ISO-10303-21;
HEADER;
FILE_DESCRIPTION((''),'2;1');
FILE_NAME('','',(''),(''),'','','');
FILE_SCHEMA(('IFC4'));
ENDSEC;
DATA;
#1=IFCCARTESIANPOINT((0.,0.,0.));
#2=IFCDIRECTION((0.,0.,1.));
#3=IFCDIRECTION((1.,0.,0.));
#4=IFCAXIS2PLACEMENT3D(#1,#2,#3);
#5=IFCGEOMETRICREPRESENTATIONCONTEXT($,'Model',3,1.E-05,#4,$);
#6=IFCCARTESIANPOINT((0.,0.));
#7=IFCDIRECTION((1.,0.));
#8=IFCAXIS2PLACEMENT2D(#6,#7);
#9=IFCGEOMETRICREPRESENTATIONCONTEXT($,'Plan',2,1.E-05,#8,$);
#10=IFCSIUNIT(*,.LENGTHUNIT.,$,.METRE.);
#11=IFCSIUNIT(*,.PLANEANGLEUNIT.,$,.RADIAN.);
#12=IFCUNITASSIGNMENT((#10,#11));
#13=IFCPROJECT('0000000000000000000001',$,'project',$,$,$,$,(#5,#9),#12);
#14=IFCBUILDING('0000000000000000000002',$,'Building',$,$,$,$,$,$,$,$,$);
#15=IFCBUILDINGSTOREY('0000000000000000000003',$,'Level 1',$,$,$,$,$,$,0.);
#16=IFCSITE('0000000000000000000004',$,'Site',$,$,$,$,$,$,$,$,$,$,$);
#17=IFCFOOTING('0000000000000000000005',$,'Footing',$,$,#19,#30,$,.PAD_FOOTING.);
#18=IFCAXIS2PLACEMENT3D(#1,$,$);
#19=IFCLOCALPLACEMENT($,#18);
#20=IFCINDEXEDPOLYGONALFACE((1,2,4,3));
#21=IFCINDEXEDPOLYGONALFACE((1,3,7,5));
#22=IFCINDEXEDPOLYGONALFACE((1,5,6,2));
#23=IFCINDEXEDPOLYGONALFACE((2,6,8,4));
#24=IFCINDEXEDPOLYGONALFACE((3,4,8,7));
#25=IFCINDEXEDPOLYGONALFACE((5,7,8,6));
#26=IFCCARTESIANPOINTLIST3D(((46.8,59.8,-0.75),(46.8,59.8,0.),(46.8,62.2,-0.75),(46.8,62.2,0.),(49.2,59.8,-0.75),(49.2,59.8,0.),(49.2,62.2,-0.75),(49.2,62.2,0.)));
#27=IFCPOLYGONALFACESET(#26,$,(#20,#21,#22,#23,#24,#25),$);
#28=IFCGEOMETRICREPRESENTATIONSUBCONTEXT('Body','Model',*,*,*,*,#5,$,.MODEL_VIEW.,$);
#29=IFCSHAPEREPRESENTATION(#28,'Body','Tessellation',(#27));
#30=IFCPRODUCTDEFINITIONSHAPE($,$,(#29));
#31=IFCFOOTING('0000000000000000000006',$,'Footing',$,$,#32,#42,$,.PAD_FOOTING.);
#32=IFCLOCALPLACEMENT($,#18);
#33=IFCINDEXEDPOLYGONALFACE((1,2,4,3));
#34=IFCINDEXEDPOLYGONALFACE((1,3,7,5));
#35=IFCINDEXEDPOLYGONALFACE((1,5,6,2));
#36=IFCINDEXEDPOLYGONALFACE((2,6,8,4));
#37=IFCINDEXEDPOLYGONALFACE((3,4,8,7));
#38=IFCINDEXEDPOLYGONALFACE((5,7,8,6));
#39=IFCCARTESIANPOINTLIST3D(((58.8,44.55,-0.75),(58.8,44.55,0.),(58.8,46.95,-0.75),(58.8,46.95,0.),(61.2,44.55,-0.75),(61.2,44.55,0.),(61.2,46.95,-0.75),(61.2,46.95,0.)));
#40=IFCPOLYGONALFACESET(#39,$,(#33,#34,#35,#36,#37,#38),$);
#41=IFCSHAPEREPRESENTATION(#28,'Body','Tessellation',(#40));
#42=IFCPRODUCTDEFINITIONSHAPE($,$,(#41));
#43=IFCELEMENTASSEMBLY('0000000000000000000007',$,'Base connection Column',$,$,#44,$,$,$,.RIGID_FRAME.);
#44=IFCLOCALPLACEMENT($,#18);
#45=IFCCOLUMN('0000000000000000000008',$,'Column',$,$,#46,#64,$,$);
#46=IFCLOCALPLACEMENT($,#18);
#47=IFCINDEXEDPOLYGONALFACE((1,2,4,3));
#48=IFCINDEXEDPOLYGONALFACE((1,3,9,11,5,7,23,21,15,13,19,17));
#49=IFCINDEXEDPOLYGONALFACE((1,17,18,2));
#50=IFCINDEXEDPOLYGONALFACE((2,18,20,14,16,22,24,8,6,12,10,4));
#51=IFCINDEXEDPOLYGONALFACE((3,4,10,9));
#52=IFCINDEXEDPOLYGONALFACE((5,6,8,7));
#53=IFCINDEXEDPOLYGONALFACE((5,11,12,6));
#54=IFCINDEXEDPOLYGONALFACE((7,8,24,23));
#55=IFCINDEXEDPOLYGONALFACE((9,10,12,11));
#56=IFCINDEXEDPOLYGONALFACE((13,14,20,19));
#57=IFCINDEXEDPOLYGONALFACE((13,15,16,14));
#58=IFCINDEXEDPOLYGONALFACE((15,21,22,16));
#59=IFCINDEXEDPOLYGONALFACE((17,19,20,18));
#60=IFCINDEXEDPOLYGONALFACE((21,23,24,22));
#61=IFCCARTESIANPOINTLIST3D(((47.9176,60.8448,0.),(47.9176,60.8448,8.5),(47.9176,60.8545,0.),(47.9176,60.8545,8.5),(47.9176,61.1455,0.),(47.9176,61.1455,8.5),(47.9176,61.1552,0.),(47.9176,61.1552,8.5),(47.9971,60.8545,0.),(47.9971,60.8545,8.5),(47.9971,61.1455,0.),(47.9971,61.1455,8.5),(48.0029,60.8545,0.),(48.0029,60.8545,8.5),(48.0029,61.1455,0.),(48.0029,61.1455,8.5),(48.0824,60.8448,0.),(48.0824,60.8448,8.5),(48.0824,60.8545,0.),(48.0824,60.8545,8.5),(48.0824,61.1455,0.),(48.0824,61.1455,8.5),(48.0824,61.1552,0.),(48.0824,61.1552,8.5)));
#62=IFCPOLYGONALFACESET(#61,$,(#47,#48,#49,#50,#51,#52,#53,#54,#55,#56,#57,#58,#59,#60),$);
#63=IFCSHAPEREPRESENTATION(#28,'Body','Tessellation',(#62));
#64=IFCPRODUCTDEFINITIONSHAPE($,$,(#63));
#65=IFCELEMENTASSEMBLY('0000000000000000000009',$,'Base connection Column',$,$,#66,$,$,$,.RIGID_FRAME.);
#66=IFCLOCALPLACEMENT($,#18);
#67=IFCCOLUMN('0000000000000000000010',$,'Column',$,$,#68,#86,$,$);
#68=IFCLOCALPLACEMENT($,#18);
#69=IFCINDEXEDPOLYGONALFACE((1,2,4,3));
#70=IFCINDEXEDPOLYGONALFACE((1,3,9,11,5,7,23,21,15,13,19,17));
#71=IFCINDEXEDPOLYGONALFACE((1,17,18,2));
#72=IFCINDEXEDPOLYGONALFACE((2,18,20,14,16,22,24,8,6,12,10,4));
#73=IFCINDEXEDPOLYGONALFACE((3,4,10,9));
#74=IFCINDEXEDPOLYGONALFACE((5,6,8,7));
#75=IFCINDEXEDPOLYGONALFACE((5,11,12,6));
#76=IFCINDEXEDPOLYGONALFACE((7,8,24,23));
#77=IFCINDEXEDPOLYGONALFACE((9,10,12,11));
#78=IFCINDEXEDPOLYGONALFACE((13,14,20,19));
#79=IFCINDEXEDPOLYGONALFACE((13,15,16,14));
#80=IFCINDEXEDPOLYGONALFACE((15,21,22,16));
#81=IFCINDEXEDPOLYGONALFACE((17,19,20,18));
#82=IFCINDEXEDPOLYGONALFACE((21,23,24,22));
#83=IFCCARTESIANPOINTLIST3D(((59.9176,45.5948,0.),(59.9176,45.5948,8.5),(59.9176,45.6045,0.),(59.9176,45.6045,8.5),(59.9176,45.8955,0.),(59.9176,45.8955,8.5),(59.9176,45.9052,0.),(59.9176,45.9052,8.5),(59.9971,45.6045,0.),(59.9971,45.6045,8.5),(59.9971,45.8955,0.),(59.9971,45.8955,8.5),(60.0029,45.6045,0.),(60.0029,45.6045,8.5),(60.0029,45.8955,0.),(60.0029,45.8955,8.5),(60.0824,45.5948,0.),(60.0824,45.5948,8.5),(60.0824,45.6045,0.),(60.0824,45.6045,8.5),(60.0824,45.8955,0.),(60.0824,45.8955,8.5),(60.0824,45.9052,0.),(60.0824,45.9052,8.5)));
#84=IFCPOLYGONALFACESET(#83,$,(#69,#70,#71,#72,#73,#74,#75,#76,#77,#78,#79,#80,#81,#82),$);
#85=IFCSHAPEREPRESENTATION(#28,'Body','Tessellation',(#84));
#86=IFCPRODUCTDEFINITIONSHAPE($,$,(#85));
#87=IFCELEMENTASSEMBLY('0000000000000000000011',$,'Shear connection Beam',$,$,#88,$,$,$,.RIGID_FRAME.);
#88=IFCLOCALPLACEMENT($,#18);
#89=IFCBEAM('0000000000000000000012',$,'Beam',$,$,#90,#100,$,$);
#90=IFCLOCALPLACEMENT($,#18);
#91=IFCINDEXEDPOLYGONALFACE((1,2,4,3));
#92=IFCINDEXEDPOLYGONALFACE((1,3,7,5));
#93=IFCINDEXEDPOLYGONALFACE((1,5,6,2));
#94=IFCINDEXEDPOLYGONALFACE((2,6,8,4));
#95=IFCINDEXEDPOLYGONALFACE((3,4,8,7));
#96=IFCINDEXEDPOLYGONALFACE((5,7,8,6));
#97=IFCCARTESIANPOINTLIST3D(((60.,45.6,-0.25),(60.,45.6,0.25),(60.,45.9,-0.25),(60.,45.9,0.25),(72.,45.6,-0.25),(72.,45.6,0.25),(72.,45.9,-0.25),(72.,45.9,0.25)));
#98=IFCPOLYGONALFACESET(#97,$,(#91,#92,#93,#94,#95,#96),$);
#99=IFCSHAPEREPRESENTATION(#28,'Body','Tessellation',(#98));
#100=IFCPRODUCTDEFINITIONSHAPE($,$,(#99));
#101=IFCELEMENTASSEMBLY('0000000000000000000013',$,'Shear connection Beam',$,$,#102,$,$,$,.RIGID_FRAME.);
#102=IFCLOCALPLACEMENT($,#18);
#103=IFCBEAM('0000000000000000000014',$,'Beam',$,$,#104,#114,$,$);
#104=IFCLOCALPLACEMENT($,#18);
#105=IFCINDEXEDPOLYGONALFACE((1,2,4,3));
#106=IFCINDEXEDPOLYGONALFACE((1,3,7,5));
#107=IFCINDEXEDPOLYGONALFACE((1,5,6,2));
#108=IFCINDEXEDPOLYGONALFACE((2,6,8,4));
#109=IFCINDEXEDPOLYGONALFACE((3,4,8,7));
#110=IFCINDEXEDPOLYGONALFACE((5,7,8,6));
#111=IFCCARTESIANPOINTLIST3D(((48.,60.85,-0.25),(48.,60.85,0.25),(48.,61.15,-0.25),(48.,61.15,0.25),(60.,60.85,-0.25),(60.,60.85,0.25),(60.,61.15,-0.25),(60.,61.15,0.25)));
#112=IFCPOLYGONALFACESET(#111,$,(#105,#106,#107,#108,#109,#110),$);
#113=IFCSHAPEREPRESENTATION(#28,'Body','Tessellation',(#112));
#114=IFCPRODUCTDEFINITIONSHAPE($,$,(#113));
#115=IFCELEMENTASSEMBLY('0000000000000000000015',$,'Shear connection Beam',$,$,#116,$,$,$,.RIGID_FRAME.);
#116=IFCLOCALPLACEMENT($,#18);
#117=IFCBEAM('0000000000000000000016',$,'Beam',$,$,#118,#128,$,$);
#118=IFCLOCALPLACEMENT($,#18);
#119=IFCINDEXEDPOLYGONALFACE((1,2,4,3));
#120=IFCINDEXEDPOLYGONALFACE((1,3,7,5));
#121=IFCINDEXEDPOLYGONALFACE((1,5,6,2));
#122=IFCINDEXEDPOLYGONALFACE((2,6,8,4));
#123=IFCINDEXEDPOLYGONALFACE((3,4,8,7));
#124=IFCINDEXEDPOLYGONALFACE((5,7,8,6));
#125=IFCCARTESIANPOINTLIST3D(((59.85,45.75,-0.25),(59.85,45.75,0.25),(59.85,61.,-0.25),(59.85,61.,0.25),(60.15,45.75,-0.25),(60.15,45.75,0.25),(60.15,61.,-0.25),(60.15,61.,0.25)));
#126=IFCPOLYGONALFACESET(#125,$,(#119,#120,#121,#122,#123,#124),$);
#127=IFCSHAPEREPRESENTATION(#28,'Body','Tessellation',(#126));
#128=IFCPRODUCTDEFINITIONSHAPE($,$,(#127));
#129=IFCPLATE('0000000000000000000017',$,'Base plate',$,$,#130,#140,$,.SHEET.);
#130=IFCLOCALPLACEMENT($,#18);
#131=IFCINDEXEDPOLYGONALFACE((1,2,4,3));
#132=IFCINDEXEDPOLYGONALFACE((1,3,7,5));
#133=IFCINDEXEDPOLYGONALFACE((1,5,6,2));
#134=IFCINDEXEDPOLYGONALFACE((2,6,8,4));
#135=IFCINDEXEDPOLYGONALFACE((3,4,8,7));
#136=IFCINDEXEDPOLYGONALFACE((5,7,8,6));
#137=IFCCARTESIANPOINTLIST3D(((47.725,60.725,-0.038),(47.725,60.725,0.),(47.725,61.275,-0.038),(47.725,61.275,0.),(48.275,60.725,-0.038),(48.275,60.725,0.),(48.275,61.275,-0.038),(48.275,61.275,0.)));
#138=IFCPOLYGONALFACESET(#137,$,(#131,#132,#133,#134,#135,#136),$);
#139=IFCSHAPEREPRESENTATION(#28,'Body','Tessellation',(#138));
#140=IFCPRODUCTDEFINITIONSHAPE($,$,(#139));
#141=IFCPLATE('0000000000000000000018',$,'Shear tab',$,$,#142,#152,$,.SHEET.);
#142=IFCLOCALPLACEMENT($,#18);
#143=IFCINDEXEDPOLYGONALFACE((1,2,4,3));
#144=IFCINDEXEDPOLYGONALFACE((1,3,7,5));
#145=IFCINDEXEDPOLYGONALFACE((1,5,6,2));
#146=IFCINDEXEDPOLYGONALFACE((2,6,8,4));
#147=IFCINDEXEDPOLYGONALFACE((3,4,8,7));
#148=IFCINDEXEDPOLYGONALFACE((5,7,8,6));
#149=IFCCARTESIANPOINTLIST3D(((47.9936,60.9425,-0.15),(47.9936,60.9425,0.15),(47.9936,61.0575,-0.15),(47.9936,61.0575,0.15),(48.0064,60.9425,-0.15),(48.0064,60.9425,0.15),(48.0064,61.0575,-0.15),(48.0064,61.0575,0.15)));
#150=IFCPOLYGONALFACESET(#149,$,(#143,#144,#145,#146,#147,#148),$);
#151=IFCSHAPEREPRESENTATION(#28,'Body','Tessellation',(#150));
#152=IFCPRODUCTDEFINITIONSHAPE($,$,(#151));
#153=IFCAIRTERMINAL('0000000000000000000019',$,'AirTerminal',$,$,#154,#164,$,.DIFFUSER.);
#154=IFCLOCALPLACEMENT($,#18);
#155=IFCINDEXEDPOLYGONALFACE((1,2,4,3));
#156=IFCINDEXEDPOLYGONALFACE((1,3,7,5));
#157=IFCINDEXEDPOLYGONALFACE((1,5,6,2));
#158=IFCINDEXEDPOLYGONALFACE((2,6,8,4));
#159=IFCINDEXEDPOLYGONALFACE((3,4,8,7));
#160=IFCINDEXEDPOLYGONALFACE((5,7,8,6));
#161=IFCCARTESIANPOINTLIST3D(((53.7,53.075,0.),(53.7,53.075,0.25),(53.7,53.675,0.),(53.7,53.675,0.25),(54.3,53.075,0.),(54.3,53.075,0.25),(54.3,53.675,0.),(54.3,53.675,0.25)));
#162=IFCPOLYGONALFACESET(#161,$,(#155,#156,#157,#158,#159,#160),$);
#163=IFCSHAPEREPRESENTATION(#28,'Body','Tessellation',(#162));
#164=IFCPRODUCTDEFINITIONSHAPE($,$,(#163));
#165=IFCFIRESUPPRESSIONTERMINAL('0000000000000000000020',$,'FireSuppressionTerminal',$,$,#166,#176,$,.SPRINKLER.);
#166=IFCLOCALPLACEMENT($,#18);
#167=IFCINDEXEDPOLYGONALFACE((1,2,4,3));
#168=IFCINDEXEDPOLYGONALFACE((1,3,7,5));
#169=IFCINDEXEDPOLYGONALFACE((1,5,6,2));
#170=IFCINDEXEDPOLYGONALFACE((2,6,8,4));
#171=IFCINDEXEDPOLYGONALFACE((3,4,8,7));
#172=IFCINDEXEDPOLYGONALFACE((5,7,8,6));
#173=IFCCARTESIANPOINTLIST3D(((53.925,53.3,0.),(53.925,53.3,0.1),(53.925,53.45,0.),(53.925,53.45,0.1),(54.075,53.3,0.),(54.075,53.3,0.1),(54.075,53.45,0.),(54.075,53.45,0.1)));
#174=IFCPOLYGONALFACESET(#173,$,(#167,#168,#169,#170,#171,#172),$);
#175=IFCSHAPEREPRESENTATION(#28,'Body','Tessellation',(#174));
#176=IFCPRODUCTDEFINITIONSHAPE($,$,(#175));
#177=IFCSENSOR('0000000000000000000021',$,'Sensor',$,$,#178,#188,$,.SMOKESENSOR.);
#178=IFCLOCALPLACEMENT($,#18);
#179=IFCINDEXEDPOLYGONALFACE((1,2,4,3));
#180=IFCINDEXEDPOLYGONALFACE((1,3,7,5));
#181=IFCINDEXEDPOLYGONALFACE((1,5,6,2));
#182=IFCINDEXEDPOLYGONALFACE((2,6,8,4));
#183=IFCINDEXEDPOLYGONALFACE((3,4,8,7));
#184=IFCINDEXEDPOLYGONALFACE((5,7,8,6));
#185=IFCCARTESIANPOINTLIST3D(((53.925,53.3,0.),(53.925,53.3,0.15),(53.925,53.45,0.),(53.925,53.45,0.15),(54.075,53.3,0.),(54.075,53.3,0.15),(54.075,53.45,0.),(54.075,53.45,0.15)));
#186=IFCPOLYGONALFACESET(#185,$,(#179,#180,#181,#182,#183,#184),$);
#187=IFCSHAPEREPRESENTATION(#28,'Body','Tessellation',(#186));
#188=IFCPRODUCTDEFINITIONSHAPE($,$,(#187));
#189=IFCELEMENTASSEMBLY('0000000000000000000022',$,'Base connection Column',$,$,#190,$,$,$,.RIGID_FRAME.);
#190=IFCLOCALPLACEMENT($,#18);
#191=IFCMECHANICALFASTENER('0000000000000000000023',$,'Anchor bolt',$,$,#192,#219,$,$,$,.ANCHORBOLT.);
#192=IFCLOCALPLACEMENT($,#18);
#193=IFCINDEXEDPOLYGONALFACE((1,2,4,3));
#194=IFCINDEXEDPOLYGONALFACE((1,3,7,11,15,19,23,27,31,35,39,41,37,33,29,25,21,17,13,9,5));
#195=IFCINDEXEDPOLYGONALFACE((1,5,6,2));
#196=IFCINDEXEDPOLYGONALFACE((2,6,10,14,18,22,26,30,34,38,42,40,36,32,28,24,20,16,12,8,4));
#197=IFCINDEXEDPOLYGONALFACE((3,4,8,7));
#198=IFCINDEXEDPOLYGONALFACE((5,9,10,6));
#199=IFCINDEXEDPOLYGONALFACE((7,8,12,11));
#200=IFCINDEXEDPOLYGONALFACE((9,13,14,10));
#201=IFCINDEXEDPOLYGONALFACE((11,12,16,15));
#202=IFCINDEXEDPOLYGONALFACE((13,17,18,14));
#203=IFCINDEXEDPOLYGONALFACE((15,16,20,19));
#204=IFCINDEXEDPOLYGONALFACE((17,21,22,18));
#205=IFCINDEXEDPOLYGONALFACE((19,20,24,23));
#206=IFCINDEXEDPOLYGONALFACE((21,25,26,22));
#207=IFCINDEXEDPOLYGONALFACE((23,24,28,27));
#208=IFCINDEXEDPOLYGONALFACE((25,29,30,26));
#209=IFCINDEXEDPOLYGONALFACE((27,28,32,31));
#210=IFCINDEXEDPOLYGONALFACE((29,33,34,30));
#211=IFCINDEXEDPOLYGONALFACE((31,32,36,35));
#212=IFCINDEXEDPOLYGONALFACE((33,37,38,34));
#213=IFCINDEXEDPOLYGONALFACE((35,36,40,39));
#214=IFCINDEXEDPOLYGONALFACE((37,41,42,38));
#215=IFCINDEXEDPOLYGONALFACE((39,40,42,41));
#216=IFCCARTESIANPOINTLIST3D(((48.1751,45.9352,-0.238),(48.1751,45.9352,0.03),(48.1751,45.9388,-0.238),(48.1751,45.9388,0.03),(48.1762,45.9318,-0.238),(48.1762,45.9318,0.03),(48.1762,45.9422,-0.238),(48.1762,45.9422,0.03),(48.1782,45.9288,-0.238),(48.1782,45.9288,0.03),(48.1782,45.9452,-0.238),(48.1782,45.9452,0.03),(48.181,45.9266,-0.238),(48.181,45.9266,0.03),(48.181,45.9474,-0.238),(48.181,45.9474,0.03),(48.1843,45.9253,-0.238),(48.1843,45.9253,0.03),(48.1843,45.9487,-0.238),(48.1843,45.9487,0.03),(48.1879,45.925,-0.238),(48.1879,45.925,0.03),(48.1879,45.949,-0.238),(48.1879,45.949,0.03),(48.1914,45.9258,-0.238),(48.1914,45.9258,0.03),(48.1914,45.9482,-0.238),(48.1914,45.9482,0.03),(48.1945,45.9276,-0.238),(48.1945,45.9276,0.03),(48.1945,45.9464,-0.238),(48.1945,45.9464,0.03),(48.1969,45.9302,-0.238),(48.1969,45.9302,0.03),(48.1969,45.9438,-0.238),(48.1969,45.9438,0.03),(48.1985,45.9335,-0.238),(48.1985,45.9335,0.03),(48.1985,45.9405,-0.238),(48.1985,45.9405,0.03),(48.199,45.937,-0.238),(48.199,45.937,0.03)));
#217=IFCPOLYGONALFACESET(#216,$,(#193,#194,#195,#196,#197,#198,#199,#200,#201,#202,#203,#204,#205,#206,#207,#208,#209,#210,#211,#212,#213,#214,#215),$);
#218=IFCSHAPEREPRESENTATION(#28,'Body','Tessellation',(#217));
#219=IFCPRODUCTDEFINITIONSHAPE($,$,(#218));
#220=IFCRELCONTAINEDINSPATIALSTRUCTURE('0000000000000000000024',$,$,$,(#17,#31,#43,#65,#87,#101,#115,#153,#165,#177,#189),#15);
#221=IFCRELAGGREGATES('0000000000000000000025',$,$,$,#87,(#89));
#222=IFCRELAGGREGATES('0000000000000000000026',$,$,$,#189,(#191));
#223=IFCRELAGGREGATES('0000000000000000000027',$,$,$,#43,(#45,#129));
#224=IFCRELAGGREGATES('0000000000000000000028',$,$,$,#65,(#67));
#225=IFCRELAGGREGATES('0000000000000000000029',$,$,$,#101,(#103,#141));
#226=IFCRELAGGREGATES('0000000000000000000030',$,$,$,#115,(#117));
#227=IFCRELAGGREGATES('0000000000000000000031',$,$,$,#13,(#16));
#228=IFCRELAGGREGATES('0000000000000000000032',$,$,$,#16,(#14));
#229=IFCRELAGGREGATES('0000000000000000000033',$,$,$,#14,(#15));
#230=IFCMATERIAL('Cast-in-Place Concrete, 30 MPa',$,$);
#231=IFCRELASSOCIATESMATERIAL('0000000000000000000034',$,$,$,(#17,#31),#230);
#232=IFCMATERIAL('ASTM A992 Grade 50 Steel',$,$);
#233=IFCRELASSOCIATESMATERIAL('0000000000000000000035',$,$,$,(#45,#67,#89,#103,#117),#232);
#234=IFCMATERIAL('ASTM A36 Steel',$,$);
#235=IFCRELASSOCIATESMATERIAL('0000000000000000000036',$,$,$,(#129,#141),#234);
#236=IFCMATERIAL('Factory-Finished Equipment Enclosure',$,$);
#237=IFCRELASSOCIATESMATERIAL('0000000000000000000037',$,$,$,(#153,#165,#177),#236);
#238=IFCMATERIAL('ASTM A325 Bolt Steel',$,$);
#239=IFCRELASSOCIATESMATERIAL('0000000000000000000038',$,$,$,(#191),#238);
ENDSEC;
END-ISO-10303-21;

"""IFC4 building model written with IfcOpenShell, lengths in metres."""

from ifc_helpers import new_model, si_unit, frame, origin_with_axes, origin_2d, origin_2d_with_axis, place, context, subcontext, project, spatial, rectangle, circle, i_section, extrude, material, element, aggregate, save


model = new_model("IFC4")

# Units and contexts
model_context = context("Model", 3, precision=1e-05, world=origin_with_axes())
plan_context = context("Plan", 2, precision=1e-05, world=origin_2d_with_axis())
body_context = subcontext(model_context, "Body", "Model", "MODEL_VIEW")
ifc_project = project(units=[si_unit("LENGTHUNIT", "METRE"), si_unit("PLANEANGLEUNIT", "RADIAN")], contexts=[model_context, plan_context])

# Site, building, storey
site = spatial("IfcSite", under=ifc_project, Name="Site")
building = spatial("IfcBuilding", under=site, Name="Building")
storey = spatial("IfcBuildingStorey", under=building, Name="Level 1", Elevation=0.0)

# Footings
ifc_material_1 = material(Name="Cast-in-Place Concrete, 30 MPa")
for number, where, z_axis, x_axis, name in (
    (1, (48.0, 61.0, -0.75), (0.0, 0.0, 1.0), (1.0, 0.0, 0.0), "Footing"),
    (2, (60.0, 45.75, -0.75), (0.0, 0.0, 1.0), (1.0, 0.0, 0.0), "Footing"),
):
    element("IfcFooting", number, at=place(None, frame(where, z_axis=z_axis, x_axis=x_axis)), inside=storey, material=ifc_material_1, Name=name, PredefinedType="PAD_FOOTING", context=body_context, shape_type="SweptSolid", body=[
        extrude(rectangle(XDim=2.4, YDim=2.4, at=origin_2d_with_axis()), origin_with_axes(), (0.0, 0.0, 1.0), 0.75),
    ])

# Element assemblies, columns
assembly_1 = element("IfcElementAssembly", 3, inside=storey, Name="Base connection Column", PredefinedType="RIGID_FRAME")
ifc_material_2 = material(Name="ASTM A992 Grade 50 Steel")
column_1_placement = place(None, frame((48.0, 61.0, 0.0), z_axis=(0.0, 0.0, 1.0), x_axis=(1.0, 0.0, 0.0)))
column_1 = element("IfcColumn", 4, at=column_1_placement, material=ifc_material_2, Name="Column", context=body_context, shape_type="SweptSolid", body=[
    extrude(i_section(OverallWidth=0.1648, OverallDepth=0.3104, WebThickness=0.0058, FlangeThickness=0.0097, at=origin_2d_with_axis()), origin_with_axes(), (0.0, 0.0, 1.0), 8.5),
])
assembly_2 = element("IfcElementAssembly", 5, inside=storey, Name="Base connection Column", PredefinedType="RIGID_FRAME")
column_2_placement = place(None, frame((60.0, 45.75, 0.0), z_axis=(0.0, 0.0, 1.0), x_axis=(1.0, 0.0, 0.0)))
column_2 = element("IfcColumn", 6, at=column_2_placement, material=ifc_material_2, Name="Column", context=body_context, shape_type="SweptSolid", body=[
    extrude(i_section(OverallWidth=0.1648, OverallDepth=0.3104, WebThickness=0.0058, FlangeThickness=0.0097, at=origin_2d_with_axis()), origin_with_axes(), (0.0, 0.0, 1.0), 8.5),
])

# Element assemblies, beams
assembly_3 = element("IfcElementAssembly", 7, inside=storey, Name="Shear connection Beam", PredefinedType="RIGID_FRAME")
beam_1_placement = place(None, frame((60.0, 45.75, 0.0), z_axis=(1.0, 0.0, 0.0), x_axis=(0.0, 1.0, 0.0)))
beam_1 = element("IfcBeam", 8, at=beam_1_placement, material=ifc_material_2, Name="Beam", context=body_context, shape_type="SweptSolid", body=[
    extrude(rectangle(XDim=0.3, YDim=0.5, at=origin_2d_with_axis()), origin_with_axes(), (0.0, 0.0, 1.0), 12.0),
])
aggregate(assembly_3, [beam_1])
assembly_4 = element("IfcElementAssembly", 9, inside=storey, Name="Shear connection Beam", PredefinedType="RIGID_FRAME")
beam_2_placement = place(None, frame((48.0, 61.0, 0.0), z_axis=(1.0, 0.0, 0.0), x_axis=(0.0, 1.0, 0.0)))
beam_2 = element("IfcBeam", 10, at=beam_2_placement, material=ifc_material_2, Name="Beam", context=body_context, shape_type="SweptSolid", body=[
    extrude(rectangle(XDim=0.3, YDim=0.5, at=origin_2d_with_axis()), origin_with_axes(), (0.0, 0.0, 1.0), 12.0),
])
assembly_5 = element("IfcElementAssembly", 11, inside=storey, Name="Shear connection Beam", PredefinedType="RIGID_FRAME")
beam_3_placement = place(None, frame((60.0, 45.75, 0.0), z_axis=(0.0, 1.0, 0.0), x_axis=(-1.0, 0.0, 0.0)))
beam_3 = element("IfcBeam", 12, at=beam_3_placement, material=ifc_material_2, Name="Beam", context=body_context, shape_type="SweptSolid", body=[
    extrude(rectangle(XDim=0.3, YDim=0.5, at=origin_2d_with_axis()), origin_with_axes(), (0.0, 0.0, 1.0), 15.25),
])

# Plates
ifc_material_3 = material(Name="ASTM A36 Steel")
plate_1_placement = place(None, frame((48.0, 61.0, -0.038), z_axis=(0.0, 0.0, 1.0), x_axis=(1.0, 0.0, 0.0)))
plate_1 = element("IfcPlate", 13, at=plate_1_placement, material=ifc_material_3, Name="Base plate", PredefinedType="SHEET", context=body_context, shape_type="SweptSolid", body=[
    extrude(rectangle(XDim=0.55, YDim=0.55, at=origin_2d_with_axis()), origin_with_axes(), (0.0, 0.0, 1.0), 0.038),
])
plate_2_placement = place(None, frame((48.0, 61.0, -0.15), z_axis=(0.0, 0.0, 1.0), x_axis=(1.0, 0.0, 0.0)))
plate_2 = element("IfcPlate", 14, at=plate_2_placement, material=ifc_material_3, Name="Shear tab", PredefinedType="SHEET", context=body_context, shape_type="SweptSolid", body=[
    extrude(rectangle(XDim=0.0127, YDim=0.115, at=origin_2d_with_axis()), origin_with_axes(), (0.0, 0.0, 1.0), 0.3),
])

# Air terminal
ifc_material_4 = material(Name="Factory-Finished Equipment Enclosure")
air_terminal_placement = place(None, frame((54.0, 53.375, 0.0), z_axis=(0.0, 0.0, 1.0), x_axis=(1.0, 0.0, 0.0)))
element("IfcAirTerminal", 15, at=air_terminal_placement, inside=storey, material=ifc_material_4, Name="AirTerminal", PredefinedType="DIFFUSER", context=body_context, shape_type="SweptSolid", body=[
    extrude(rectangle(XDim=0.6, YDim=0.6, at=origin_2d_with_axis()), origin_with_axes(), (0.0, 0.0, 1.0), 0.25),
])

# Fire suppression terminal
fire_suppression_terminal_placement = place(None, frame((54.0, 53.375, 0.0), z_axis=(0.0, 0.0, 1.0), x_axis=(1.0, 0.0, 0.0)))
element("IfcFireSuppressionTerminal", 16, at=fire_suppression_terminal_placement, inside=storey, material=ifc_material_4, Name="FireSuppressionTerminal", PredefinedType="SPRINKLER", context=body_context, shape_type="SweptSolid", body=[
    extrude(rectangle(XDim=0.15, YDim=0.15, at=origin_2d_with_axis()), origin_with_axes(), (0.0, 0.0, 1.0), 0.1),
])

# Sensor
sensor_placement = place(None, frame((54.0, 53.375, 0.0), z_axis=(0.0, 0.0, 1.0), x_axis=(1.0, 0.0, 0.0)))
element("IfcSensor", 17, at=sensor_placement, inside=storey, material=ifc_material_4, Name="Sensor", PredefinedType="SMOKESENSOR", context=body_context, shape_type="SweptSolid", body=[
    extrude(rectangle(XDim=0.15, YDim=0.15, at=origin_2d_with_axis()), origin_with_axes(), (0.0, 0.0, 1.0), 0.15),
])

# Element assembly, mechanical fastener
assembly_6 = element("IfcElementAssembly", 18, inside=storey, Name="Base connection Column", PredefinedType="RIGID_FRAME")
ifc_material_5 = material(Name="ASTM A325 Bolt Steel")
mechanical_fastener_1_placement = place(None, frame((48.187, 45.937, -0.238), z_axis=(0.0, 0.0, 1.0), x_axis=(1.0, 0.0, 0.0)))
mechanical_fastener_1 = element("IfcMechanicalFastener", 19, at=mechanical_fastener_1_placement, material=ifc_material_5, Name="Anchor bolt", PredefinedType="ANCHORBOLT", context=body_context, shape_type="SweptSolid", body=[
    extrude(circle(Radius=0.012, at=origin_2d()), origin_with_axes(), (0.0, 0.0, 1.0), 0.268),
])
aggregate(assembly_6, [mechanical_fastener_1])

aggregate(assembly_1, [column_1, plate_1])
aggregate(assembly_2, [column_2])

aggregate(assembly_4, [beam_2, plate_2])

aggregate(assembly_5, [beam_3])

save(model, "model.ifc")
